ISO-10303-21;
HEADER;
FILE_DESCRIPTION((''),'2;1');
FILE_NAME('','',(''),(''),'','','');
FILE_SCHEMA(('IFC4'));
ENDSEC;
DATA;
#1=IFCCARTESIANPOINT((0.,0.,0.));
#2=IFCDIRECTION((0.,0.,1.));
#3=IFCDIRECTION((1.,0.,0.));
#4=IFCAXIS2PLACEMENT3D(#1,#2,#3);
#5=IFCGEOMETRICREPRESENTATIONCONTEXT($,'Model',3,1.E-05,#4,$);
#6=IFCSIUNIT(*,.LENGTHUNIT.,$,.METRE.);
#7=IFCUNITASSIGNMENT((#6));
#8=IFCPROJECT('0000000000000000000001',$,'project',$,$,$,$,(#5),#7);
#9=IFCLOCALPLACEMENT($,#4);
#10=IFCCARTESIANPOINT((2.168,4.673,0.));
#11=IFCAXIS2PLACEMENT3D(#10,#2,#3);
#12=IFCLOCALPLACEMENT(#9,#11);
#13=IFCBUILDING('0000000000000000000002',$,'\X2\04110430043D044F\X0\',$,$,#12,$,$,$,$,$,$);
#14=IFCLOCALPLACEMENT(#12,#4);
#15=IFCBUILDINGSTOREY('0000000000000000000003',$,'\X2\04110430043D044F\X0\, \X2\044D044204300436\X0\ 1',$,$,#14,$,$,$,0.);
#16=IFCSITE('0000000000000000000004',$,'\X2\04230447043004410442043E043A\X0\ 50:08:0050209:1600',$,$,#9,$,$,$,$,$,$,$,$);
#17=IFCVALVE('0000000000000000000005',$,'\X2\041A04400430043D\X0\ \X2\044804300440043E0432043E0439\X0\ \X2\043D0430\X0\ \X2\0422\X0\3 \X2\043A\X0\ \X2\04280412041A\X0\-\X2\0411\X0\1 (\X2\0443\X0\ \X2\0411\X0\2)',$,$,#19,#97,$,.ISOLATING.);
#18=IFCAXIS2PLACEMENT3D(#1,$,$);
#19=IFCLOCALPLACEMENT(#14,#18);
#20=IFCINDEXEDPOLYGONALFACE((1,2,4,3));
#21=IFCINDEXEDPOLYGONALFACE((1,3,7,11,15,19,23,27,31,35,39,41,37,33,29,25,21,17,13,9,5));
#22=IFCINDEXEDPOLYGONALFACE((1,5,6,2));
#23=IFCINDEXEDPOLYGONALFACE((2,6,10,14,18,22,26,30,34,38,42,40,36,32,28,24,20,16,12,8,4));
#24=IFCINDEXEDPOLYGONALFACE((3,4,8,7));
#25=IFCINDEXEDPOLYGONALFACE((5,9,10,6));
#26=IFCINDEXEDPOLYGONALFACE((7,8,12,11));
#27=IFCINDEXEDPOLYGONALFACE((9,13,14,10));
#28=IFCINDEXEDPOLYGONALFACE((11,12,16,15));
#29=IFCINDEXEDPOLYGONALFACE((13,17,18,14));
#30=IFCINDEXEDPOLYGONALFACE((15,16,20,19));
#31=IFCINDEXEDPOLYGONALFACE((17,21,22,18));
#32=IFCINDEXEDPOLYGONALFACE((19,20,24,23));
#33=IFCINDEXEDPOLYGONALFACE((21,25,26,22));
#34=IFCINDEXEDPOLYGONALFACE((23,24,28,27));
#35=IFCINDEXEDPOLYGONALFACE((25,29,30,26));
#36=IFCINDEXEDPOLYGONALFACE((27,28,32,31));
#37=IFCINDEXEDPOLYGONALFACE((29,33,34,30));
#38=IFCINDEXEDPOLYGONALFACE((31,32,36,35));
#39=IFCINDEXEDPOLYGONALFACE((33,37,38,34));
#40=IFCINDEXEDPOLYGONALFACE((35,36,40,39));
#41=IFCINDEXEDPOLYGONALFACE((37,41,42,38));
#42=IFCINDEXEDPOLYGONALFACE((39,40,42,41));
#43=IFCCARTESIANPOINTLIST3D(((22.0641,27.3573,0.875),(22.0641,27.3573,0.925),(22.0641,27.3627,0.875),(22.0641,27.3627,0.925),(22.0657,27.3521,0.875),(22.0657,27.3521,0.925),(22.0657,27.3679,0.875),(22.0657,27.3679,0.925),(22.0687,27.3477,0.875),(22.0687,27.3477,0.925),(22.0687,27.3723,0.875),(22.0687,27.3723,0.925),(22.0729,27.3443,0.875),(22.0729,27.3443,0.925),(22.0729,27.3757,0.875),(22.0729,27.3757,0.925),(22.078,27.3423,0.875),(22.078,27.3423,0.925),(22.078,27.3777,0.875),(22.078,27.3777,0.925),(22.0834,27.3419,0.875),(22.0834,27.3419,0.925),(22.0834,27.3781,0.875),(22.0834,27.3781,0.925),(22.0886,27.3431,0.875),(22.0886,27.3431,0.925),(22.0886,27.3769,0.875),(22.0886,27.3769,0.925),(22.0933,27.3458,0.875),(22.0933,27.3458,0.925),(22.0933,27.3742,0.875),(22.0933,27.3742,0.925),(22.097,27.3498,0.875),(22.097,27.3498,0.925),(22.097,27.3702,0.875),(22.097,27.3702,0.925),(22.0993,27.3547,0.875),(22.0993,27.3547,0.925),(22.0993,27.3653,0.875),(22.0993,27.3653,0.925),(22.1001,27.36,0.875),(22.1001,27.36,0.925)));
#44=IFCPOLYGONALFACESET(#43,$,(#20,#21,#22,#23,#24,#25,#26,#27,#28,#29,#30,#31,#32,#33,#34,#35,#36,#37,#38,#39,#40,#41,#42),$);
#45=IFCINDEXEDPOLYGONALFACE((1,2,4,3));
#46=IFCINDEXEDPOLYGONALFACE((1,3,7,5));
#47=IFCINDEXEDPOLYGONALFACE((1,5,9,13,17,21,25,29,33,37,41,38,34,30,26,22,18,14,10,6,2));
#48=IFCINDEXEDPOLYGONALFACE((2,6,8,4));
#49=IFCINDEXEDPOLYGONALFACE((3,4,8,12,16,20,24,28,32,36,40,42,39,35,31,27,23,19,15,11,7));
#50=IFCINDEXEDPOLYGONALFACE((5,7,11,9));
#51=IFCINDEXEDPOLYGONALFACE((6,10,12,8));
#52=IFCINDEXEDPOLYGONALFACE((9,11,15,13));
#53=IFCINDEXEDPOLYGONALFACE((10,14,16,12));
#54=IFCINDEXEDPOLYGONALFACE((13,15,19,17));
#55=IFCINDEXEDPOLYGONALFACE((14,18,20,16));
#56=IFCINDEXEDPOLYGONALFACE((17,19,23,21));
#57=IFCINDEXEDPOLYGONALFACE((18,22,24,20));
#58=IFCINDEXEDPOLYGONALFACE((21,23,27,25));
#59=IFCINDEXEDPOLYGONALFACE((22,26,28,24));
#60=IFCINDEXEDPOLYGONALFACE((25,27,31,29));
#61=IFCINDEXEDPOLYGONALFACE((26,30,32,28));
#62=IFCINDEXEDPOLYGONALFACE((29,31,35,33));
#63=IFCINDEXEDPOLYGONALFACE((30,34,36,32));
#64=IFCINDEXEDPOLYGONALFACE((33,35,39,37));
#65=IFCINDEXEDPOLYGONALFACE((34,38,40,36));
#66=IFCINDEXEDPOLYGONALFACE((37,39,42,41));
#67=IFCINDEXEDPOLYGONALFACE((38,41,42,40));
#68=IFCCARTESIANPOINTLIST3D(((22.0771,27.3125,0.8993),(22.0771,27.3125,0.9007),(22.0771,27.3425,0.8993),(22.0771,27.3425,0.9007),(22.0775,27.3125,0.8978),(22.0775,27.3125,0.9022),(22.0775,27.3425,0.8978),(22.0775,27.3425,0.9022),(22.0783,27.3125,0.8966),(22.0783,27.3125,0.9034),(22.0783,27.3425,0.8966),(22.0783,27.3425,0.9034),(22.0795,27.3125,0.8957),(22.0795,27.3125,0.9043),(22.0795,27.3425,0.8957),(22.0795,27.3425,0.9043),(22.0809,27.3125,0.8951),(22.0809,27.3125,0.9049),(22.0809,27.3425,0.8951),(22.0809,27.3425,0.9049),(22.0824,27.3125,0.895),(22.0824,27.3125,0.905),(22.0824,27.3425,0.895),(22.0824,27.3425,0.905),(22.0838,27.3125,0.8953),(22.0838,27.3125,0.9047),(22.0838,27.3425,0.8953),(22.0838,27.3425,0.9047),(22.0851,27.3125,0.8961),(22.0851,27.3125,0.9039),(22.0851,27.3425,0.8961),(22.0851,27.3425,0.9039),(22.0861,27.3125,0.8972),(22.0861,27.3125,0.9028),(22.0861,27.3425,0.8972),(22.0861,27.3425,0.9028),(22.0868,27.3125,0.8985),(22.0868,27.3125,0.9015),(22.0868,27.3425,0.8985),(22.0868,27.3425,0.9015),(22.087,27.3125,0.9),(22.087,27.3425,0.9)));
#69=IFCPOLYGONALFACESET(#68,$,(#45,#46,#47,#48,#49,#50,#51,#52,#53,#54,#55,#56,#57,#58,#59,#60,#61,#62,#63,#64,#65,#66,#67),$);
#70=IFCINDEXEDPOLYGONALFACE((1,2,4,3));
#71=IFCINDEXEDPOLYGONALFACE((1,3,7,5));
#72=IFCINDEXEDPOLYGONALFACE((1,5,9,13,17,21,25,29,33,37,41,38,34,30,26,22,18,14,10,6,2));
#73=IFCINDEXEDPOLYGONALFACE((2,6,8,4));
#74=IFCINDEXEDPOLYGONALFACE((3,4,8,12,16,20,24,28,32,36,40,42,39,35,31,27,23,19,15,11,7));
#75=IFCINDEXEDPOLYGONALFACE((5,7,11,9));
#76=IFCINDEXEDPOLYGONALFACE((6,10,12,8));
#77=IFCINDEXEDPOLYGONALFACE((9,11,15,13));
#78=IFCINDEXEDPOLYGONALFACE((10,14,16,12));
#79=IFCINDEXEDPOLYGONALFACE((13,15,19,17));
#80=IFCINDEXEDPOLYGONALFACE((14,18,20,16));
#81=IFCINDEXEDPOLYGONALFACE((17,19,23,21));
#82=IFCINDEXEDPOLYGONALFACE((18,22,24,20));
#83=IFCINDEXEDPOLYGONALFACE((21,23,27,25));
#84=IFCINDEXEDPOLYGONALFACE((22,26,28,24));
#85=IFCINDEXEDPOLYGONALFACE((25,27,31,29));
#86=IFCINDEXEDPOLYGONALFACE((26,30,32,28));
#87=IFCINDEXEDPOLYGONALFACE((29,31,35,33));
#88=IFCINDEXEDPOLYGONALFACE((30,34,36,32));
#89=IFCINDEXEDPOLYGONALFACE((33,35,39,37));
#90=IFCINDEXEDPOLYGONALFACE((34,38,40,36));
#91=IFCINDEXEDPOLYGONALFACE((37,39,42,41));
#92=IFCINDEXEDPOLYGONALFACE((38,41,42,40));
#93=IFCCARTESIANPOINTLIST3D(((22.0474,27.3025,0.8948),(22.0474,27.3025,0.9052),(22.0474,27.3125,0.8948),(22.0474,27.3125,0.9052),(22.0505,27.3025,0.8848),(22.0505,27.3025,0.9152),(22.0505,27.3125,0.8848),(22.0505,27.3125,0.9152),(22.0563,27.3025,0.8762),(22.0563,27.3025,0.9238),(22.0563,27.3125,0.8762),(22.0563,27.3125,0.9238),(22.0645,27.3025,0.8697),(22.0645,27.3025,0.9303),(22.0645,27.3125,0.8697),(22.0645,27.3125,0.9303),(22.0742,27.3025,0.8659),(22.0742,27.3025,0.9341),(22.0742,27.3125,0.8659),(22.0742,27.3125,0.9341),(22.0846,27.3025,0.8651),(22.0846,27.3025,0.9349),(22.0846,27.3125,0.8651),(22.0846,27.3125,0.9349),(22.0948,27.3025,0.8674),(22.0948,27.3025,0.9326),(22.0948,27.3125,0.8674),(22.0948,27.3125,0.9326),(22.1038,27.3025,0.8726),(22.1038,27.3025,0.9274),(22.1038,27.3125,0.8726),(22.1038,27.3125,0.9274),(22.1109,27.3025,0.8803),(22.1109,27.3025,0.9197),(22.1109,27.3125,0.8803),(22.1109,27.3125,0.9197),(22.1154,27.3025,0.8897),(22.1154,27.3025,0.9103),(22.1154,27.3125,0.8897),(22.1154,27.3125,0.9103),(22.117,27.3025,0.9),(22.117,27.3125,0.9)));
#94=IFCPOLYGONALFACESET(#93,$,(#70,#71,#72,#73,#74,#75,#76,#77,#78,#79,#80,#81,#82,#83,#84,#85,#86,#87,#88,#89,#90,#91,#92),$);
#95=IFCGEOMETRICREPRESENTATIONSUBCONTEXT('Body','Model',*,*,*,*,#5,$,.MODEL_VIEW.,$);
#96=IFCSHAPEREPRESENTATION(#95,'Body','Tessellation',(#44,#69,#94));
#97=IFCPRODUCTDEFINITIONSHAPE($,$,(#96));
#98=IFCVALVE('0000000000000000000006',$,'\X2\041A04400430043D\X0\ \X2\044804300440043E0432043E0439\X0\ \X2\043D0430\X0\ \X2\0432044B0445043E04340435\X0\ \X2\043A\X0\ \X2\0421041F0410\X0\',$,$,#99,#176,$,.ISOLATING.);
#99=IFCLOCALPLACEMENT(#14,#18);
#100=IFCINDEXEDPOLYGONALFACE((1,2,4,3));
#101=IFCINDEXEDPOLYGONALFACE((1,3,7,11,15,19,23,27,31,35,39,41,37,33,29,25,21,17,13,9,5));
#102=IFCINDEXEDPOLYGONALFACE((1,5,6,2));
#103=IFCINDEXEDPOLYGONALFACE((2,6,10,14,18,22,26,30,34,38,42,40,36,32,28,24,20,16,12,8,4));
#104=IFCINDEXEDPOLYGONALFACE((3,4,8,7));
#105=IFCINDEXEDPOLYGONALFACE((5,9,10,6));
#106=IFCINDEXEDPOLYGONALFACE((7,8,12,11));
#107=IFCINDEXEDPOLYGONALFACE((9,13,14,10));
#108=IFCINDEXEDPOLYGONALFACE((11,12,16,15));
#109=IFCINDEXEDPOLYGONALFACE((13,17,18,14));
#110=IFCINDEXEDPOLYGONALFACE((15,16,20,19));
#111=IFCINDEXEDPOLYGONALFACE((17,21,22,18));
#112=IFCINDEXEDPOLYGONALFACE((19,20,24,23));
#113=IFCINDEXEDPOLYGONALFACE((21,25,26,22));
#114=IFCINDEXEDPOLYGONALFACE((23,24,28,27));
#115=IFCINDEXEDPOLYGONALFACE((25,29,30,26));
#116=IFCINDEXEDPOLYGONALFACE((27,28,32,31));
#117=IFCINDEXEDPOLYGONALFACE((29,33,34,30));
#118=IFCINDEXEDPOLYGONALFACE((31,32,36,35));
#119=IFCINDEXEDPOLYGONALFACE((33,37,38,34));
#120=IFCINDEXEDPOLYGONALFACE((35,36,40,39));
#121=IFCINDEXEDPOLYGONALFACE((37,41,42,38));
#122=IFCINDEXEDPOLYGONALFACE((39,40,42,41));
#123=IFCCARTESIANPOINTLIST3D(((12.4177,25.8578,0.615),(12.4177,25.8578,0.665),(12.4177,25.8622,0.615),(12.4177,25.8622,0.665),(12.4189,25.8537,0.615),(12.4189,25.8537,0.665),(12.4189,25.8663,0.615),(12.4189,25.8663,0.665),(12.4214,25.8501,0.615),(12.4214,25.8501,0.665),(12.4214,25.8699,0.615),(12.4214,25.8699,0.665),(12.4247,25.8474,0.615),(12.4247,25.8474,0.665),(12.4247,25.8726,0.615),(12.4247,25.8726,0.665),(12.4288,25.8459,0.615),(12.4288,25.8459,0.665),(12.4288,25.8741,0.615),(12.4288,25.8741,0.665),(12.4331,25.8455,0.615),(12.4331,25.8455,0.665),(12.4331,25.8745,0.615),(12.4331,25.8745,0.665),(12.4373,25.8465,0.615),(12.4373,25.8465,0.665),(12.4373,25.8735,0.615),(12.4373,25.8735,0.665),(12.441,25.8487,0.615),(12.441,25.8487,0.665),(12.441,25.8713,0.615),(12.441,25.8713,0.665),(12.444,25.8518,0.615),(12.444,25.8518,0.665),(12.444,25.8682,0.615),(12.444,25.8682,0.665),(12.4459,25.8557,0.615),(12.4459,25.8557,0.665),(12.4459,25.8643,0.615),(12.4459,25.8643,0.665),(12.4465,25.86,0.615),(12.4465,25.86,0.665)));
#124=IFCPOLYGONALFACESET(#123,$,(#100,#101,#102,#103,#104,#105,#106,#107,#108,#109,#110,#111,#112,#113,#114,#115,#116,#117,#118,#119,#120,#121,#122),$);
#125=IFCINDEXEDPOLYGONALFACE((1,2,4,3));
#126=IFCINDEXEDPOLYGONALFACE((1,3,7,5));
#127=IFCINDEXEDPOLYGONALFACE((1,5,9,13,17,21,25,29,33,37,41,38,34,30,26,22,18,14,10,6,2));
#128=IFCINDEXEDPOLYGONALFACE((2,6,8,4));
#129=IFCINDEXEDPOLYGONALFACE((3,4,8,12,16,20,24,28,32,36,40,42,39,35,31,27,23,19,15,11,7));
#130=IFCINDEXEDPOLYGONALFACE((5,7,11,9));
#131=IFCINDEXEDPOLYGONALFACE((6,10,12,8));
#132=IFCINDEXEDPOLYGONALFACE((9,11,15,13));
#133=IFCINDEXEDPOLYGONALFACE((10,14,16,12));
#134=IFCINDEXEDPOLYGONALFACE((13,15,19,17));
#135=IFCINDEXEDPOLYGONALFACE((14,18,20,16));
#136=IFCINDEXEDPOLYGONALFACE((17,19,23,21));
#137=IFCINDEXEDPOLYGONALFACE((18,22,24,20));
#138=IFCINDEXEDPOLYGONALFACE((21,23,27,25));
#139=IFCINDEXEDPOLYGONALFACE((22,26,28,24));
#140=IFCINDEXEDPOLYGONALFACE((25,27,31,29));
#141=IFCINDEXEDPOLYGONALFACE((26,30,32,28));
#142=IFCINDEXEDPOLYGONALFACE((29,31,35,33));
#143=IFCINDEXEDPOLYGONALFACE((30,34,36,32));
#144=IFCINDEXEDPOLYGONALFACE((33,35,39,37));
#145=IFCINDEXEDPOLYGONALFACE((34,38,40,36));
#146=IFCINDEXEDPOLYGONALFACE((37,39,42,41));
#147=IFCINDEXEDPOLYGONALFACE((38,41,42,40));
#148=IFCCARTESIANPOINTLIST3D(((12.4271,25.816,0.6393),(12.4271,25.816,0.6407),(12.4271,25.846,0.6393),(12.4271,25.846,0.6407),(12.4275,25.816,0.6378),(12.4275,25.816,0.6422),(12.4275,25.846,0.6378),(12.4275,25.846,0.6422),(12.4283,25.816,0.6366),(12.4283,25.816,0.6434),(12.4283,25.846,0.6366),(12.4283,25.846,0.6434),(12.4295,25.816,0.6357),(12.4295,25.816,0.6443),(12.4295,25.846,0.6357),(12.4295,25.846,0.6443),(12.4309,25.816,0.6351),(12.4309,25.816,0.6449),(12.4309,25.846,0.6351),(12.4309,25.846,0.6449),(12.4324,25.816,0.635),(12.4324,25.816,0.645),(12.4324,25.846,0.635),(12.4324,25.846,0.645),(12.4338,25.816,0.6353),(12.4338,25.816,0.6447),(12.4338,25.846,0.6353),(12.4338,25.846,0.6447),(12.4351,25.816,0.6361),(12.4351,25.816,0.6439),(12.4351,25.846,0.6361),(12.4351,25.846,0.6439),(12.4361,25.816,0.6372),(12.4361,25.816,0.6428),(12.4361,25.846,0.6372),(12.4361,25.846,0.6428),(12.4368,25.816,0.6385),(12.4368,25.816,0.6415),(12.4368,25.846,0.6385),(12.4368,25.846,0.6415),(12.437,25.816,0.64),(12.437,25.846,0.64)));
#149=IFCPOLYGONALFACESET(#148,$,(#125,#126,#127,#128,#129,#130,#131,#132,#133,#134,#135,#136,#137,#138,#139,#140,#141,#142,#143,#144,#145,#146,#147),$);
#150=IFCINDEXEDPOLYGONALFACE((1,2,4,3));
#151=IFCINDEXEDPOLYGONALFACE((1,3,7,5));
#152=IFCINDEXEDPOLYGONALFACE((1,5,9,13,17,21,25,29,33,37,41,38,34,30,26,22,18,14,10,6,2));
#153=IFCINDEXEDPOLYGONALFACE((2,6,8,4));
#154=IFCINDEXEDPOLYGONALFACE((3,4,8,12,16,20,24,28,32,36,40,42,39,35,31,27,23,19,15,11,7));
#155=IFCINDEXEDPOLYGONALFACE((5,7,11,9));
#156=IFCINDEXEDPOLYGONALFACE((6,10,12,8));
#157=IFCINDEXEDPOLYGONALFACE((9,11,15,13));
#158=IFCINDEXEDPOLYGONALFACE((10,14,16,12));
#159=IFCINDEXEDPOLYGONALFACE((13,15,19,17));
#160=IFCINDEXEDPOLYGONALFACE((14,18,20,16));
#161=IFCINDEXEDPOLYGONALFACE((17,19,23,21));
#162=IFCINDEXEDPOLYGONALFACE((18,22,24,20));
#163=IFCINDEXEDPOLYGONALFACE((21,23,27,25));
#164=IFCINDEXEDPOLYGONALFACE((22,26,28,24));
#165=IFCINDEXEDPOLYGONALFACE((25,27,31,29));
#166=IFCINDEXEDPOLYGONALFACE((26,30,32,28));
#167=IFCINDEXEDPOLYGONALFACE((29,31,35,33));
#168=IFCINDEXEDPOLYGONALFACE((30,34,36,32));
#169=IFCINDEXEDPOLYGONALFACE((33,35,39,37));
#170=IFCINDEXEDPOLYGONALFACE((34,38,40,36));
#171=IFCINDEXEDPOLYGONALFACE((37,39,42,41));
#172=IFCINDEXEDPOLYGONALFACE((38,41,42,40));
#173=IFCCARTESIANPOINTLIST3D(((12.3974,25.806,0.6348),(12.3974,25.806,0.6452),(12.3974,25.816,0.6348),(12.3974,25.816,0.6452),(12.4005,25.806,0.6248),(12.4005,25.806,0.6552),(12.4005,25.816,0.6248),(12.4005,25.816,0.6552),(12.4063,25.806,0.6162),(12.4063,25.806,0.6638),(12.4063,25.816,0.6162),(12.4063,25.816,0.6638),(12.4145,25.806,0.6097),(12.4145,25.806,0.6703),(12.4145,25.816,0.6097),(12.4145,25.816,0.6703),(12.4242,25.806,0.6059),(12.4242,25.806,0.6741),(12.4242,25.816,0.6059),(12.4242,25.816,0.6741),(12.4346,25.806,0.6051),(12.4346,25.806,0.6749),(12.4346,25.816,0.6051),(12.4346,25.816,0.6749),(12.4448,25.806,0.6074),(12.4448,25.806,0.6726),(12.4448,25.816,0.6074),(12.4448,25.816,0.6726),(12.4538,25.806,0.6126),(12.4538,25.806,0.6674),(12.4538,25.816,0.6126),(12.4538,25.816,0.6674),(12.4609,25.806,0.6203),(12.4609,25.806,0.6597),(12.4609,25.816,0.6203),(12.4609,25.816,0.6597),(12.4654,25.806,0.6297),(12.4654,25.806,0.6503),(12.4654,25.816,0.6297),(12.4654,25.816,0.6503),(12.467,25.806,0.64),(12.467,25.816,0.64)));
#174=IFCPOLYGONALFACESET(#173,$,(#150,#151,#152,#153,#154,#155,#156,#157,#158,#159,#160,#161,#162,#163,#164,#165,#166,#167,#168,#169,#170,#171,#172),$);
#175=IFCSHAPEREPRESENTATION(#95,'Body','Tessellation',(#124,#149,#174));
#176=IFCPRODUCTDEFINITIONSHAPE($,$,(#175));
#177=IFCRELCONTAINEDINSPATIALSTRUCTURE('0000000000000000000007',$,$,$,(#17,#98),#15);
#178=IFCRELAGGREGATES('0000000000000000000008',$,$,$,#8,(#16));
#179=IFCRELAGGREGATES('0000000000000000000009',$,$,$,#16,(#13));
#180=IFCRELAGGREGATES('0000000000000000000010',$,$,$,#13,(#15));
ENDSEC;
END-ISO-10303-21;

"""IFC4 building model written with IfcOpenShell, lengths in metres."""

from ifc_helpers import new_model, si_unit, frame, origin_with_axes, origin_2d, place, context, subcontext, project, spatial, circle, extrude, element, save


model = new_model("IFC4")

# Units and contexts
model_context = context("Model", 3, precision=1e-05, world=origin_with_axes())
body_context = subcontext(model_context, "Body", "Model", "MODEL_VIEW")
ifc_project = project(units=[si_unit("LENGTHUNIT", "METRE")], contexts=[model_context])

# Site, building, storey
site_placement = place(None, origin_with_axes())
site = spatial("IfcSite", under=ifc_project, at=site_placement, Name="Участок 50:08:0050209:1600")
building_placement = place(site_placement, frame((2.168, 4.673, 0.0), z_axis=(0.0, 0.0, 1.0), x_axis=(1.0, 0.0, 0.0)))
building = spatial("IfcBuilding", under=site, at=building_placement, Name="Баня")
storey_placement = place(building_placement, origin_with_axes())
storey = spatial("IfcBuildingStorey", under=building, at=storey_placement, Name="Баня, этаж 1", Elevation=0.0)

# Valves
valve_1_placement = place(storey_placement, origin_with_axes())
element("IfcValve", 1, at=valve_1_placement, inside=storey, Name="Кран шаровой на Т3 к ШВК-Б1 (у Б2)", PredefinedType="ISOLATING", context=body_context, shape_type="SweptSolid", body=[
    extrude(circle(Radius=0.0181, at=origin_2d()), frame((22.082, 27.36, 0.875), z_axis=(0.0, 0.0, 1.0), x_axis=(1.0, 0.0, 0.0)), (0.0, 0.0, 1.0), 0.05),
    extrude(circle(Radius=0.005, at=origin_2d()), frame((22.082, 27.3425, 0.9), z_axis=(0.0, -1.0, 0.0), x_axis=(1.0, 0.0, 0.0)), (0.0, 0.0, 1.0), 0.03),
    extrude(circle(Radius=0.035, at=origin_2d()), frame((22.082, 27.3125, 0.9), z_axis=(0.0, -1.0, 0.0), x_axis=(1.0, 0.0, 0.0)), (0.0, 0.0, 1.0), 0.01),
])
valve_2_placement = place(storey_placement, origin_with_axes())
element("IfcValve", 2, at=valve_2_placement, inside=storey, Name="Кран шаровой на выходе к СПА", PredefinedType="ISOLATING", context=body_context, shape_type="SweptSolid", body=[
    extrude(circle(Radius=0.0145, at=origin_2d()), frame((12.432, 25.86, 0.615), z_axis=(0.0, 0.0, 1.0), x_axis=(1.0, 0.0, 0.0)), (0.0, 0.0, 1.0), 0.05),
    extrude(circle(Radius=0.005, at=origin_2d()), frame((12.432, 25.846, 0.64), z_axis=(0.0, -1.0, 0.0), x_axis=(1.0, 0.0, 0.0)), (0.0, 0.0, 1.0), 0.03),
    extrude(circle(Radius=0.035, at=origin_2d()), frame((12.432, 25.816, 0.64), z_axis=(0.0, -1.0, 0.0), x_axis=(1.0, 0.0, 0.0)), (0.0, 0.0, 1.0), 0.01),
])

save(model, "model.ifc")
